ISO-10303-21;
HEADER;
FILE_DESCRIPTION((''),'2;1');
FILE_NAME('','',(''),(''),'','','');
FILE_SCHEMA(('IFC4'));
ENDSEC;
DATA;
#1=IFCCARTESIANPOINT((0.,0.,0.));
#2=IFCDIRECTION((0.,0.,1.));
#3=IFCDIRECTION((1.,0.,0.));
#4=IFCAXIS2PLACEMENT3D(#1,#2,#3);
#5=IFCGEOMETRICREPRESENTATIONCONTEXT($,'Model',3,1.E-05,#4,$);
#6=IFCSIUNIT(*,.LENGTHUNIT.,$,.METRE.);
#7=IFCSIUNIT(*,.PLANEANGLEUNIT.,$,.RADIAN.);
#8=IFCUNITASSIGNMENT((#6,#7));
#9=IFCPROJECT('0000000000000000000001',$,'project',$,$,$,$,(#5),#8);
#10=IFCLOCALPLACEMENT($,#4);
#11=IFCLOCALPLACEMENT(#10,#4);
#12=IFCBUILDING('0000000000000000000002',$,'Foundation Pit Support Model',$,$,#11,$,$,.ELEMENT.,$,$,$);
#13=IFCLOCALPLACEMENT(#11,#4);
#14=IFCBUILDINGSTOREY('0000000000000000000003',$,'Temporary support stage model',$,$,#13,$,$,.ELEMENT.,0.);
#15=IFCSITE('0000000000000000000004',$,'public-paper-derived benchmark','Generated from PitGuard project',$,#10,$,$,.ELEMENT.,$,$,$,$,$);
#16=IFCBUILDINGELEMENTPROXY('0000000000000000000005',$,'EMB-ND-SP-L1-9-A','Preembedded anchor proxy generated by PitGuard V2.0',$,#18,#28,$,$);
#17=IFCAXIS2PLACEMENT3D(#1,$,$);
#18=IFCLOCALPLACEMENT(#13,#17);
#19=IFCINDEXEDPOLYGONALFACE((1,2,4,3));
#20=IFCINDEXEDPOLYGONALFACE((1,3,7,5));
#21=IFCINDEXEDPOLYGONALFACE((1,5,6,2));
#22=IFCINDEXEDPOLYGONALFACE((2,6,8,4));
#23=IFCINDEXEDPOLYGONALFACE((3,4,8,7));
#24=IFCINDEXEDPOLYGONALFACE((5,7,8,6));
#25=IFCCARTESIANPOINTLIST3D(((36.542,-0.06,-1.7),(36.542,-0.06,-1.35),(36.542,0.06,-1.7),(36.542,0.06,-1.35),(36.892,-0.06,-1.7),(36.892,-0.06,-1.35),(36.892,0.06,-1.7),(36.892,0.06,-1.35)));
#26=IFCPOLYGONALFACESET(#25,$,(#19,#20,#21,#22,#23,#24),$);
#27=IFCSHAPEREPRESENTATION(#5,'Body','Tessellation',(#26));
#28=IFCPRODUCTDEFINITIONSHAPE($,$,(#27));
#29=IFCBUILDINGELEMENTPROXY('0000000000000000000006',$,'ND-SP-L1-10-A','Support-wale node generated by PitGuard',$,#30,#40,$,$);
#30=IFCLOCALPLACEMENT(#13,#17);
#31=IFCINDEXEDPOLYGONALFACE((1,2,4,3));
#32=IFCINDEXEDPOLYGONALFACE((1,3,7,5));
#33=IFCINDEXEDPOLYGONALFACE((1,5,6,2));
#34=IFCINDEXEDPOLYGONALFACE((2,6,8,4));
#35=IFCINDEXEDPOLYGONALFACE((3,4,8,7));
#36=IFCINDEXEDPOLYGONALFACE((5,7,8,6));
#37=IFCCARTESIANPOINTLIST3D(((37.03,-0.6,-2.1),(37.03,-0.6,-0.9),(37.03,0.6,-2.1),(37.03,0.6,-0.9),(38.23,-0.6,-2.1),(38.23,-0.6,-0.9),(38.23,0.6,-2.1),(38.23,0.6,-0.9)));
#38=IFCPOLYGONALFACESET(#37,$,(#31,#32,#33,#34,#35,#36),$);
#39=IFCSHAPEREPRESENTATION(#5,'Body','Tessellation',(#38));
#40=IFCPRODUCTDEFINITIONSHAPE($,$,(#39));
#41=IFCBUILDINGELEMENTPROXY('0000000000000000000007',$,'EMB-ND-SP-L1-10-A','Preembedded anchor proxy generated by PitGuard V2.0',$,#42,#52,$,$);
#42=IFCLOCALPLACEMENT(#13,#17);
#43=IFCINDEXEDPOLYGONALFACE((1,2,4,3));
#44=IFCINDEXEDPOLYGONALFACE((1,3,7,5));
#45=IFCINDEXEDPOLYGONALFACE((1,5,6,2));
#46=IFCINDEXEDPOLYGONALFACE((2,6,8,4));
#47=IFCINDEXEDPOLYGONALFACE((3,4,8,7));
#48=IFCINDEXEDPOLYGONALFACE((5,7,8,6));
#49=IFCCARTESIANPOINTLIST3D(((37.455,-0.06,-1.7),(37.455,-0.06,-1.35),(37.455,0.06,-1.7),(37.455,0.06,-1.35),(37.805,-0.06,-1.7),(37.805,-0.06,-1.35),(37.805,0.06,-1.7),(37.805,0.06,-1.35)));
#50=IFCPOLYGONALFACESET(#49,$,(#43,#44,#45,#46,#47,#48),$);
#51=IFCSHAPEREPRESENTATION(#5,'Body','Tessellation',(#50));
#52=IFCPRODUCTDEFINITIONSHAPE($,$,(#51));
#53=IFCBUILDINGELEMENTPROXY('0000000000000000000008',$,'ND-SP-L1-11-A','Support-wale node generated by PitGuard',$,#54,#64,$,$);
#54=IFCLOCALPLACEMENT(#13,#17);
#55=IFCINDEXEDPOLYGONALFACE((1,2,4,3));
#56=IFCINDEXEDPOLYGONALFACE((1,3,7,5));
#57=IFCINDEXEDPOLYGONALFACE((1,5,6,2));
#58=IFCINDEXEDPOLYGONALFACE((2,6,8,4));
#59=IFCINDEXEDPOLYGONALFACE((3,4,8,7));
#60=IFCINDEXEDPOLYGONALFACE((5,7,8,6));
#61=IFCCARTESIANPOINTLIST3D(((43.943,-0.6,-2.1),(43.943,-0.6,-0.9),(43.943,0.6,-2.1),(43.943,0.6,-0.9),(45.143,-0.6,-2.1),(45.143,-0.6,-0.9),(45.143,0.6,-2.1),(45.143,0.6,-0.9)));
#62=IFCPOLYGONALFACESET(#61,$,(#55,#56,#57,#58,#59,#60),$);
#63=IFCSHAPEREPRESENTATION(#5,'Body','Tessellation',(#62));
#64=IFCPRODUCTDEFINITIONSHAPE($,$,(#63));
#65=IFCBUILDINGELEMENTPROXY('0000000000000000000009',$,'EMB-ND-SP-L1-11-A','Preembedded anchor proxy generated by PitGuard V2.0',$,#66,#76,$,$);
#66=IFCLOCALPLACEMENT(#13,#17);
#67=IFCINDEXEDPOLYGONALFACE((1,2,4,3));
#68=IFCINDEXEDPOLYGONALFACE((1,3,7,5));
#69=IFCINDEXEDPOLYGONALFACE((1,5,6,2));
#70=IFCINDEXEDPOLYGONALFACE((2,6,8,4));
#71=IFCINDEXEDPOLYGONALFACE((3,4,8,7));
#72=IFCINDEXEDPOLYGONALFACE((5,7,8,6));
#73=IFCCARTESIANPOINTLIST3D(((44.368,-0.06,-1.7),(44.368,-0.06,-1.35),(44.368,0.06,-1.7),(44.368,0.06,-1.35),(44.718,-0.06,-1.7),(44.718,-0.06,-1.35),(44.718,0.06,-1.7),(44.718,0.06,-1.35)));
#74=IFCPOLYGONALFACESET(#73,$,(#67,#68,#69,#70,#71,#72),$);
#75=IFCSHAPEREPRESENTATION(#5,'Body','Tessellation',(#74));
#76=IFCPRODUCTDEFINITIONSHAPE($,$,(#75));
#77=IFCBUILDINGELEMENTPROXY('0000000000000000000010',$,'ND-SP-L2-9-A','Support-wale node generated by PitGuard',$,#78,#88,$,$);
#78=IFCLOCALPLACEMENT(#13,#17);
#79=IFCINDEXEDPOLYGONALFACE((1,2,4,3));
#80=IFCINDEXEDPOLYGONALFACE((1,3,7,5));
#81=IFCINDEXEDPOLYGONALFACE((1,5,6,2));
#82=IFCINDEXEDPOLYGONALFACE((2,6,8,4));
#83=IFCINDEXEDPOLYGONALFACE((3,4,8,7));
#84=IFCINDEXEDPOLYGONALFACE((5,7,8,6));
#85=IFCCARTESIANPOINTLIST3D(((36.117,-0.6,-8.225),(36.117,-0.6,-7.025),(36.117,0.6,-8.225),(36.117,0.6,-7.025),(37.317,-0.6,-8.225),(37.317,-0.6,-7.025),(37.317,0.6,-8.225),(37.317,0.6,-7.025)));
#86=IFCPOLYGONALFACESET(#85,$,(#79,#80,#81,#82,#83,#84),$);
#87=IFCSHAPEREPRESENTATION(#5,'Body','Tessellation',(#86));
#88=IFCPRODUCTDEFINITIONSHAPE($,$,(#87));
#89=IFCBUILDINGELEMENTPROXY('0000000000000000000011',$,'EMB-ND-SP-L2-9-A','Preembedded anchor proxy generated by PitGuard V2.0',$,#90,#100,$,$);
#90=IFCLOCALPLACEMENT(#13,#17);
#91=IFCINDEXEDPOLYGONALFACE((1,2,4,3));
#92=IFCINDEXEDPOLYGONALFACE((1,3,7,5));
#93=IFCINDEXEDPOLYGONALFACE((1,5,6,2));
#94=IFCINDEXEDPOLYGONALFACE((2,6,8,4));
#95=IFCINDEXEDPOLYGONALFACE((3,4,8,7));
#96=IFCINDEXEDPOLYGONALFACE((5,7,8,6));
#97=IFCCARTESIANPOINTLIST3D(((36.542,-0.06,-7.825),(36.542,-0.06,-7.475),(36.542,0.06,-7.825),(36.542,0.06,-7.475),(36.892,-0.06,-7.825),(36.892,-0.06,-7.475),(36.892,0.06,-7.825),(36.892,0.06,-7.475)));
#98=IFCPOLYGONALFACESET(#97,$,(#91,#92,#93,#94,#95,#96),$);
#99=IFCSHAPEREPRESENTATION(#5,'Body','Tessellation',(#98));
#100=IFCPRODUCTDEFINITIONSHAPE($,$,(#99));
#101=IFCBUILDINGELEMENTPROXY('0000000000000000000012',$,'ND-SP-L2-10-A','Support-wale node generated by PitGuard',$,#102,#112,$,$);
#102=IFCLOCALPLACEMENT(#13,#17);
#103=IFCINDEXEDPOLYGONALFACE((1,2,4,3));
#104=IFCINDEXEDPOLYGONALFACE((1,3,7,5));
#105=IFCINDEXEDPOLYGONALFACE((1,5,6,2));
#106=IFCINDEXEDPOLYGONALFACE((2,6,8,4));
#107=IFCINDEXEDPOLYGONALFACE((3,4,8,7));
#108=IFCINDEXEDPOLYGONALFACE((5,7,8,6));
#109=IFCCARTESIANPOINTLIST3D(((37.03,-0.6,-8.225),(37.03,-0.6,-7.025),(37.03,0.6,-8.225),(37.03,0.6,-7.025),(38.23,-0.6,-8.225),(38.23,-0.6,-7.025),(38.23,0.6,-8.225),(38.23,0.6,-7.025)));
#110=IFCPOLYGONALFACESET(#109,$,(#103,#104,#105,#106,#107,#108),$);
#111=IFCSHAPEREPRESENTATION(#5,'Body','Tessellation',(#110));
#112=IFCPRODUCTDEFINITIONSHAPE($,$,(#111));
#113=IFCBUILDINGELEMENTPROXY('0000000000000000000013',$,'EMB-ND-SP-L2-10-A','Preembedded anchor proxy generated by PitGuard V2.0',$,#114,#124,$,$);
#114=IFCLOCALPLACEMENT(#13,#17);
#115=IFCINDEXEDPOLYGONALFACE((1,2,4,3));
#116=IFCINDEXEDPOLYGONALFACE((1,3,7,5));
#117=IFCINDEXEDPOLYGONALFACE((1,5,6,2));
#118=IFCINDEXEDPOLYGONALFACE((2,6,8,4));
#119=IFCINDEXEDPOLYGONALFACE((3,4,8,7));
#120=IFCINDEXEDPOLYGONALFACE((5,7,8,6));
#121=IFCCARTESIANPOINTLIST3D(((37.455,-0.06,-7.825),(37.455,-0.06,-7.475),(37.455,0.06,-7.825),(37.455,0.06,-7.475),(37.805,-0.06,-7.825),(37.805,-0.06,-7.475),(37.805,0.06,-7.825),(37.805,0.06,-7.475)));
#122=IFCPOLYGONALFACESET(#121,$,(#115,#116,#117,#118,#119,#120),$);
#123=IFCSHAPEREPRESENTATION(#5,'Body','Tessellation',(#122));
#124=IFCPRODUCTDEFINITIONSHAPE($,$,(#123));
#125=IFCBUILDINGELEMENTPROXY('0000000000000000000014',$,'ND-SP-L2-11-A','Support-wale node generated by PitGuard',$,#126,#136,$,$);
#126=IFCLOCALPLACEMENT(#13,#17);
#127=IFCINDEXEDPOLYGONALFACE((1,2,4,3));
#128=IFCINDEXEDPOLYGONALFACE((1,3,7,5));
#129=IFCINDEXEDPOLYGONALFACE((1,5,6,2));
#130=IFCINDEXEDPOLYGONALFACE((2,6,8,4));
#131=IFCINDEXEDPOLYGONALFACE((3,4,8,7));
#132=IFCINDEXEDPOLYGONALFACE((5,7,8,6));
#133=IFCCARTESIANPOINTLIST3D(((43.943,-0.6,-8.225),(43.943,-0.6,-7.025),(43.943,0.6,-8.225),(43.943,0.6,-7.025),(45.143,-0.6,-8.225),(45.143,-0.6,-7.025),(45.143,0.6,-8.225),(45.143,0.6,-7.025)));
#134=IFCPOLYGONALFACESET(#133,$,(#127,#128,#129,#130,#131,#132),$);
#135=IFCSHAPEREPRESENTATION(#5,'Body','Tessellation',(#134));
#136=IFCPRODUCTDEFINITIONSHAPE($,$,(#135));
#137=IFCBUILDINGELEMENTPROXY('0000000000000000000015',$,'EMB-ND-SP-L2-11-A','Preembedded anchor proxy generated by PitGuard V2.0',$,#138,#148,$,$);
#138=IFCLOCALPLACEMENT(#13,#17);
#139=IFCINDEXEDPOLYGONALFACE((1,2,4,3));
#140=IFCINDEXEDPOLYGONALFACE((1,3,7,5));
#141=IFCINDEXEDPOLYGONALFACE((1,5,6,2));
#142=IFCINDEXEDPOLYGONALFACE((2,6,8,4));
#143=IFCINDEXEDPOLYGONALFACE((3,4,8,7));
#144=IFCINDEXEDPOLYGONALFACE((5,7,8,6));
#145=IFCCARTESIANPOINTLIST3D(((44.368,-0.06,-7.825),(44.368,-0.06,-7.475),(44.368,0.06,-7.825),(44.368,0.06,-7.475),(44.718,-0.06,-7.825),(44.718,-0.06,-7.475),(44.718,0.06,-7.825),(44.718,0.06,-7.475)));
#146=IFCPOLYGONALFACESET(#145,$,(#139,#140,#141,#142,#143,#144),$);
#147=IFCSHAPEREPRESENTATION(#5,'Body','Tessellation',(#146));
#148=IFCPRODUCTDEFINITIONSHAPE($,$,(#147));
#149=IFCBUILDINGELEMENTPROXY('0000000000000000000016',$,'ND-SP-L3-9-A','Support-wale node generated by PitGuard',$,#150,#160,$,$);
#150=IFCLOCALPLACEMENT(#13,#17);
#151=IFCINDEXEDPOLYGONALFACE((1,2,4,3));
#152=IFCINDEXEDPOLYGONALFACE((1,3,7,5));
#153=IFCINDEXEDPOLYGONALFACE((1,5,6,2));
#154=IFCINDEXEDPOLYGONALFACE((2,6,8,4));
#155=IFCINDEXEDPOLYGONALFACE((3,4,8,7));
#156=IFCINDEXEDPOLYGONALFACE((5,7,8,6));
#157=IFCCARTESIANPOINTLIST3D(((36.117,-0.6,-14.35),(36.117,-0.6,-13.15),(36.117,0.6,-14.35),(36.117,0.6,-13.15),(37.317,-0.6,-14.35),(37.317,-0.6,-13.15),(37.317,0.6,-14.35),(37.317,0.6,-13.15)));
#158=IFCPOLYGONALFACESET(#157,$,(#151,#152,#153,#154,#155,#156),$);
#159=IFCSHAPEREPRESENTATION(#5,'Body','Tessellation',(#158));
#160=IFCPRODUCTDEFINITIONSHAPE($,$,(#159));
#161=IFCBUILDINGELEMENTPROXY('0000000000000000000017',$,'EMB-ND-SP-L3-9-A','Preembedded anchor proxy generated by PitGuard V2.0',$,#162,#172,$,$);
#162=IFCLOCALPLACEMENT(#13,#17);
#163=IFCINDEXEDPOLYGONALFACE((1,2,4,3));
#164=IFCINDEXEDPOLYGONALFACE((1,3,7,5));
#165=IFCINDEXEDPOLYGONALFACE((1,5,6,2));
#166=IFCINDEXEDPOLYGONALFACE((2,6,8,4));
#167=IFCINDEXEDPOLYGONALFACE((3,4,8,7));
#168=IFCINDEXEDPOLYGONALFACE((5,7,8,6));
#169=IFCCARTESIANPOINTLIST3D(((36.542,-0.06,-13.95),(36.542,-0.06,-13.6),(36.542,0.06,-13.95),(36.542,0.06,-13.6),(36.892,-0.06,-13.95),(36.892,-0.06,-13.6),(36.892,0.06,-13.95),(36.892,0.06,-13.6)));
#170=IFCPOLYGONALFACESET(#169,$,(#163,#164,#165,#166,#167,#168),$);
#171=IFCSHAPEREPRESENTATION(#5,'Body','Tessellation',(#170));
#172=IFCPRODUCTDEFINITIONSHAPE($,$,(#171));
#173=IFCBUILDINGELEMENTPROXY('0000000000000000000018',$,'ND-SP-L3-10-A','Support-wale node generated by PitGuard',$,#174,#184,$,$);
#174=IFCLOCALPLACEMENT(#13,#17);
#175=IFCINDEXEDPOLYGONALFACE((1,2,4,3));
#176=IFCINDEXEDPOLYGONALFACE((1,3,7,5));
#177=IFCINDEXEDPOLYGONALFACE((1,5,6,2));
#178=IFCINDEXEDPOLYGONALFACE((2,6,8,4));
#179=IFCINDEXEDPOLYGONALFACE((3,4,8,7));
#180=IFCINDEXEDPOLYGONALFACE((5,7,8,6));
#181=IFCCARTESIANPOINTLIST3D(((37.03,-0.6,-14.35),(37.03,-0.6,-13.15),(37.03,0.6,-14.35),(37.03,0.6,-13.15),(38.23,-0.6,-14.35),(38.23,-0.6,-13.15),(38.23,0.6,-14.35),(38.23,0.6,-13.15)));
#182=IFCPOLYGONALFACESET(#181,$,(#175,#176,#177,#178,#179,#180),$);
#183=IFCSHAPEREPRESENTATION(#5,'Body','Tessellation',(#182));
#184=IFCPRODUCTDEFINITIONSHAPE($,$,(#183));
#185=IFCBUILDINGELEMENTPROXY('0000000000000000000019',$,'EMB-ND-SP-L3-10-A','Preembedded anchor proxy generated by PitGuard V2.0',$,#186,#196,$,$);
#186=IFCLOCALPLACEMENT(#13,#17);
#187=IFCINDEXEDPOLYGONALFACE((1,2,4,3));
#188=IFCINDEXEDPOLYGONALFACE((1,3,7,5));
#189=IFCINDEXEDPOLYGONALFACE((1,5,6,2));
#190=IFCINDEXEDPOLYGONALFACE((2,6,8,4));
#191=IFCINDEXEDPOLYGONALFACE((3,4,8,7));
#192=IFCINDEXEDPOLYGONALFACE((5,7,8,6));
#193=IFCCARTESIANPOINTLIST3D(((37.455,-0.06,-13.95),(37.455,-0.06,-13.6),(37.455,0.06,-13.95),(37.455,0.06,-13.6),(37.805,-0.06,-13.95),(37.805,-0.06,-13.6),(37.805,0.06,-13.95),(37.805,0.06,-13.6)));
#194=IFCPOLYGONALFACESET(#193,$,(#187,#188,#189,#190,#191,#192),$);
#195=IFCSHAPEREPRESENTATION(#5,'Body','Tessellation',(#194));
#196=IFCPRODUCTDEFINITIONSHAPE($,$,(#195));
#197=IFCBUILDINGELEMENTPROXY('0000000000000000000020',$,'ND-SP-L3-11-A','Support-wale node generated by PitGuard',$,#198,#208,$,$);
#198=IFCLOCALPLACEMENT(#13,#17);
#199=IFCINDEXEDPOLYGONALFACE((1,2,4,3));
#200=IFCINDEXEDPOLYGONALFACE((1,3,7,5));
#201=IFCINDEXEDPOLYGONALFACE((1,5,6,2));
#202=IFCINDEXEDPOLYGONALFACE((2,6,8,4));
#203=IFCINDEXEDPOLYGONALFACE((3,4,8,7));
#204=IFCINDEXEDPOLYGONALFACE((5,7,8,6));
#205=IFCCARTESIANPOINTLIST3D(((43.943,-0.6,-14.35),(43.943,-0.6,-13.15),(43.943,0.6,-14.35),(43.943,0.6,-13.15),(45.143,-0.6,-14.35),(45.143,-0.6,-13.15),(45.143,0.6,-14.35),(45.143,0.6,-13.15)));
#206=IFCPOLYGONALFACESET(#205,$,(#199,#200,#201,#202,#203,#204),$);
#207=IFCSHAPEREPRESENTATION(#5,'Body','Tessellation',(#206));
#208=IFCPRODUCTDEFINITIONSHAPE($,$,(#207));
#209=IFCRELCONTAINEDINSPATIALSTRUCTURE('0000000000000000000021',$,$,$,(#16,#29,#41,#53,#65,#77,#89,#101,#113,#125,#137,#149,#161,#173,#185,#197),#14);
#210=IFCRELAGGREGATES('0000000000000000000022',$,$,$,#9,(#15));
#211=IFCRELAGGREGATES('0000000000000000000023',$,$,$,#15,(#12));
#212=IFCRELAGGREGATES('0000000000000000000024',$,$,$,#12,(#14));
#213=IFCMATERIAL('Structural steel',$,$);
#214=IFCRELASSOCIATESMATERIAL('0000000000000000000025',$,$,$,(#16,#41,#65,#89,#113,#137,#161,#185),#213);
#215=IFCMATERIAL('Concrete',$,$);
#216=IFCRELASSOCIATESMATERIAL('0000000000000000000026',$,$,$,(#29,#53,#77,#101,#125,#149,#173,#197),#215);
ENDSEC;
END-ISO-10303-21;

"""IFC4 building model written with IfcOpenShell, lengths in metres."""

from ifc_helpers import new_model, si_unit, frame, origin_with_axes, origin_2d, place, context, project, spatial, rectangle, extrude, material, element, save


model = new_model("IFC4")

# Units and contexts
model_context = context("Model", 3, precision=1e-05, world=origin_with_axes())
ifc_project = project(units=[si_unit("LENGTHUNIT", "METRE"), si_unit("PLANEANGLEUNIT", "RADIAN")], contexts=[model_context])

# Site, building, storey
site_placement = place(None, origin_with_axes())
site = spatial("IfcSite", under=ifc_project, at=site_placement, Name="public-paper-derived benchmark", Description="Generated from PitGuard project", CompositionType="ELEMENT")
building_placement = place(site_placement, origin_with_axes())
building = spatial("IfcBuilding", under=site, at=building_placement, Name="Foundation Pit Support Model", CompositionType="ELEMENT")
storey_placement = place(building_placement, origin_with_axes())
storey = spatial("IfcBuildingStorey", under=building, at=storey_placement, Name="Temporary support stage model", CompositionType="ELEMENT", Elevation=0.0)

# Shared definitions
ifc_material_1 = material(Name="Concrete")

# Shared definitions
ifc_material_2 = material(Name="Structural steel")

# Building element proxies
proxy_1_placement = place(storey_placement, frame((36.717, 0.0, -1.7), z_axis=(0.0, 0.0, 1.0), x_axis=(1.0, 0.0, 0.0)))
element("IfcBuildingElementProxy", 1, at=proxy_1_placement, inside=storey, material=ifc_material_2, Name="EMB-ND-SP-L1-9-A", Description="Preembedded anchor proxy generated by PitGuard V2.0", context=model_context, shape_type="SweptSolid", body=[
    extrude(rectangle(XDim=0.35, YDim=0.12, at=origin_2d()), origin_with_axes(), (0.0, 0.0, 1.0), 0.35),
])
proxy_2_placement = place(storey_placement, frame((37.63, 0.0, -2.1), z_axis=(0.0, 0.0, 1.0), x_axis=(1.0, 0.0, 0.0)))
element("IfcBuildingElementProxy", 2, at=proxy_2_placement, inside=storey, material=ifc_material_1, Name="ND-SP-L1-10-A", Description="Support-wale node generated by PitGuard", context=model_context, shape_type="SweptSolid", body=[
    extrude(rectangle(XDim=1.2, YDim=1.2, at=origin_2d()), origin_with_axes(), (0.0, 0.0, 1.0), 1.2),
])
proxy_3_placement = place(storey_placement, frame((37.63, 0.0, -1.7), z_axis=(0.0, 0.0, 1.0), x_axis=(1.0, 0.0, 0.0)))
element("IfcBuildingElementProxy", 3, at=proxy_3_placement, inside=storey, material=ifc_material_2, Name="EMB-ND-SP-L1-10-A", Description="Preembedded anchor proxy generated by PitGuard V2.0", context=model_context, shape_type="SweptSolid", body=[
    extrude(rectangle(XDim=0.35, YDim=0.12, at=origin_2d()), origin_with_axes(), (0.0, 0.0, 1.0), 0.35),
])
proxy_4_placement = place(storey_placement, frame((44.543, 0.0, -2.1), z_axis=(0.0, 0.0, 1.0), x_axis=(1.0, 0.0, 0.0)))
element("IfcBuildingElementProxy", 4, at=proxy_4_placement, inside=storey, material=ifc_material_1, Name="ND-SP-L1-11-A", Description="Support-wale node generated by PitGuard", context=model_context, shape_type="SweptSolid", body=[
    extrude(rectangle(XDim=1.2, YDim=1.2, at=origin_2d()), origin_with_axes(), (0.0, 0.0, 1.0), 1.2),
])
proxy_5_placement = place(storey_placement, frame((44.543, 0.0, -1.7), z_axis=(0.0, 0.0, 1.0), x_axis=(1.0, 0.0, 0.0)))
element("IfcBuildingElementProxy", 5, at=proxy_5_placement, inside=storey, material=ifc_material_2, Name="EMB-ND-SP-L1-11-A", Description="Preembedded anchor proxy generated by PitGuard V2.0", context=model_context, shape_type="SweptSolid", body=[
    extrude(rectangle(XDim=0.35, YDim=0.12, at=origin_2d()), origin_with_axes(), (0.0, 0.0, 1.0), 0.35),
])
proxy_6_placement = place(storey_placement, frame((36.717, 0.0, -8.225), z_axis=(0.0, 0.0, 1.0), x_axis=(1.0, 0.0, 0.0)))
element("IfcBuildingElementProxy", 6, at=proxy_6_placement, inside=storey, material=ifc_material_1, Name="ND-SP-L2-9-A", Description="Support-wale node generated by PitGuard", context=model_context, shape_type="SweptSolid", body=[
    extrude(rectangle(XDim=1.2, YDim=1.2, at=origin_2d()), origin_with_axes(), (0.0, 0.0, 1.0), 1.2),
])
proxy_7_placement = place(storey_placement, frame((36.717, 0.0, -7.825), z_axis=(0.0, 0.0, 1.0), x_axis=(1.0, 0.0, 0.0)))
element("IfcBuildingElementProxy", 7, at=proxy_7_placement, inside=storey, material=ifc_material_2, Name="EMB-ND-SP-L2-9-A", Description="Preembedded anchor proxy generated by PitGuard V2.0", context=model_context, shape_type="SweptSolid", body=[
    extrude(rectangle(XDim=0.35, YDim=0.12, at=origin_2d()), origin_with_axes(), (0.0, 0.0, 1.0), 0.35),
])
proxy_8_placement = place(storey_placement, frame((37.63, 0.0, -8.225), z_axis=(0.0, 0.0, 1.0), x_axis=(1.0, 0.0, 0.0)))
element("IfcBuildingElementProxy", 8, at=proxy_8_placement, inside=storey, material=ifc_material_1, Name="ND-SP-L2-10-A", Description="Support-wale node generated by PitGuard", context=model_context, shape_type="SweptSolid", body=[
    extrude(rectangle(XDim=1.2, YDim=1.2, at=origin_2d()), origin_with_axes(), (0.0, 0.0, 1.0), 1.2),
])
proxy_9_placement = place(storey_placement, frame((37.63, 0.0, -7.825), z_axis=(0.0, 0.0, 1.0), x_axis=(1.0, 0.0, 0.0)))
element("IfcBuildingElementProxy", 9, at=proxy_9_placement, inside=storey, material=ifc_material_2, Name="EMB-ND-SP-L2-10-A", Description="Preembedded anchor proxy generated by PitGuard V2.0", context=model_context, shape_type="SweptSolid", body=[
    extrude(rectangle(XDim=0.35, YDim=0.12, at=origin_2d()), origin_with_axes(), (0.0, 0.0, 1.0), 0.35),
])
proxy_10_placement = place(storey_placement, frame((44.543, 0.0, -8.225), z_axis=(0.0, 0.0, 1.0), x_axis=(1.0, 0.0, 0.0)))
element("IfcBuildingElementProxy", 10, at=proxy_10_placement, inside=storey, material=ifc_material_1, Name="ND-SP-L2-11-A", Description="Support-wale node generated by PitGuard", context=model_context, shape_type="SweptSolid", body=[
    extrude(rectangle(XDim=1.2, YDim=1.2, at=origin_2d()), origin_with_axes(), (0.0, 0.0, 1.0), 1.2),
])
proxy_11_placement = place(storey_placement, frame((44.543, 0.0, -7.825), z_axis=(0.0, 0.0, 1.0), x_axis=(1.0, 0.0, 0.0)))
element("IfcBuildingElementProxy", 11, at=proxy_11_placement, inside=storey, material=ifc_material_2, Name="EMB-ND-SP-L2-11-A", Description="Preembedded anchor proxy generated by PitGuard V2.0", context=model_context, shape_type="SweptSolid", body=[
    extrude(rectangle(XDim=0.35, YDim=0.12, at=origin_2d()), origin_with_axes(), (0.0, 0.0, 1.0), 0.35),
])
proxy_12_placement = place(storey_placement, frame((36.717, 0.0, -14.35), z_axis=(0.0, 0.0, 1.0), x_axis=(1.0, 0.0, 0.0)))
element("IfcBuildingElementProxy", 12, at=proxy_12_placement, inside=storey, material=ifc_material_1, Name="ND-SP-L3-9-A", Description="Support-wale node generated by PitGuard", context=model_context, shape_type="SweptSolid", body=[
    extrude(rectangle(XDim=1.2, YDim=1.2, at=origin_2d()), origin_with_axes(), (0.0, 0.0, 1.0), 1.2),
])
proxy_13_placement = place(storey_placement, frame((36.717, 0.0, -13.95), z_axis=(0.0, 0.0, 1.0), x_axis=(1.0, 0.0, 0.0)))
element("IfcBuildingElementProxy", 13, at=proxy_13_placement, inside=storey, material=ifc_material_2, Name="EMB-ND-SP-L3-9-A", Description="Preembedded anchor proxy generated by PitGuard V2.0", context=model_context, shape_type="SweptSolid", body=[
    extrude(rectangle(XDim=0.35, YDim=0.12, at=origin_2d()), origin_with_axes(), (0.0, 0.0, 1.0), 0.35),
])
proxy_14_placement = place(storey_placement, frame((37.63, 0.0, -14.35), z_axis=(0.0, 0.0, 1.0), x_axis=(1.0, 0.0, 0.0)))
element("IfcBuildingElementProxy", 14, at=proxy_14_placement, inside=storey, material=ifc_material_1, Name="ND-SP-L3-10-A", Description="Support-wale node generated by PitGuard", context=model_context, shape_type="SweptSolid", body=[
    extrude(rectangle(XDim=1.2, YDim=1.2, at=origin_2d()), origin_with_axes(), (0.0, 0.0, 1.0), 1.2),
])
proxy_15_placement = place(storey_placement, frame((37.63, 0.0, -13.95), z_axis=(0.0, 0.0, 1.0), x_axis=(1.0, 0.0, 0.0)))
element("IfcBuildingElementProxy", 15, at=proxy_15_placement, inside=storey, material=ifc_material_2, Name="EMB-ND-SP-L3-10-A", Description="Preembedded anchor proxy generated by PitGuard V2.0", context=model_context, shape_type="SweptSolid", body=[
    extrude(rectangle(XDim=0.35, YDim=0.12, at=origin_2d()), origin_with_axes(), (0.0, 0.0, 1.0), 0.35),
])
proxy_16_placement = place(storey_placement, frame((44.543, 0.0, -14.35), z_axis=(0.0, 0.0, 1.0), x_axis=(1.0, 0.0, 0.0)))
element("IfcBuildingElementProxy", 16, at=proxy_16_placement, inside=storey, material=ifc_material_1, Name="ND-SP-L3-11-A", Description="Support-wale node generated by PitGuard", context=model_context, shape_type="SweptSolid", body=[
    extrude(rectangle(XDim=1.2, YDim=1.2, at=origin_2d()), origin_with_axes(), (0.0, 0.0, 1.0), 1.2),
])

save(model, "model.ifc")
